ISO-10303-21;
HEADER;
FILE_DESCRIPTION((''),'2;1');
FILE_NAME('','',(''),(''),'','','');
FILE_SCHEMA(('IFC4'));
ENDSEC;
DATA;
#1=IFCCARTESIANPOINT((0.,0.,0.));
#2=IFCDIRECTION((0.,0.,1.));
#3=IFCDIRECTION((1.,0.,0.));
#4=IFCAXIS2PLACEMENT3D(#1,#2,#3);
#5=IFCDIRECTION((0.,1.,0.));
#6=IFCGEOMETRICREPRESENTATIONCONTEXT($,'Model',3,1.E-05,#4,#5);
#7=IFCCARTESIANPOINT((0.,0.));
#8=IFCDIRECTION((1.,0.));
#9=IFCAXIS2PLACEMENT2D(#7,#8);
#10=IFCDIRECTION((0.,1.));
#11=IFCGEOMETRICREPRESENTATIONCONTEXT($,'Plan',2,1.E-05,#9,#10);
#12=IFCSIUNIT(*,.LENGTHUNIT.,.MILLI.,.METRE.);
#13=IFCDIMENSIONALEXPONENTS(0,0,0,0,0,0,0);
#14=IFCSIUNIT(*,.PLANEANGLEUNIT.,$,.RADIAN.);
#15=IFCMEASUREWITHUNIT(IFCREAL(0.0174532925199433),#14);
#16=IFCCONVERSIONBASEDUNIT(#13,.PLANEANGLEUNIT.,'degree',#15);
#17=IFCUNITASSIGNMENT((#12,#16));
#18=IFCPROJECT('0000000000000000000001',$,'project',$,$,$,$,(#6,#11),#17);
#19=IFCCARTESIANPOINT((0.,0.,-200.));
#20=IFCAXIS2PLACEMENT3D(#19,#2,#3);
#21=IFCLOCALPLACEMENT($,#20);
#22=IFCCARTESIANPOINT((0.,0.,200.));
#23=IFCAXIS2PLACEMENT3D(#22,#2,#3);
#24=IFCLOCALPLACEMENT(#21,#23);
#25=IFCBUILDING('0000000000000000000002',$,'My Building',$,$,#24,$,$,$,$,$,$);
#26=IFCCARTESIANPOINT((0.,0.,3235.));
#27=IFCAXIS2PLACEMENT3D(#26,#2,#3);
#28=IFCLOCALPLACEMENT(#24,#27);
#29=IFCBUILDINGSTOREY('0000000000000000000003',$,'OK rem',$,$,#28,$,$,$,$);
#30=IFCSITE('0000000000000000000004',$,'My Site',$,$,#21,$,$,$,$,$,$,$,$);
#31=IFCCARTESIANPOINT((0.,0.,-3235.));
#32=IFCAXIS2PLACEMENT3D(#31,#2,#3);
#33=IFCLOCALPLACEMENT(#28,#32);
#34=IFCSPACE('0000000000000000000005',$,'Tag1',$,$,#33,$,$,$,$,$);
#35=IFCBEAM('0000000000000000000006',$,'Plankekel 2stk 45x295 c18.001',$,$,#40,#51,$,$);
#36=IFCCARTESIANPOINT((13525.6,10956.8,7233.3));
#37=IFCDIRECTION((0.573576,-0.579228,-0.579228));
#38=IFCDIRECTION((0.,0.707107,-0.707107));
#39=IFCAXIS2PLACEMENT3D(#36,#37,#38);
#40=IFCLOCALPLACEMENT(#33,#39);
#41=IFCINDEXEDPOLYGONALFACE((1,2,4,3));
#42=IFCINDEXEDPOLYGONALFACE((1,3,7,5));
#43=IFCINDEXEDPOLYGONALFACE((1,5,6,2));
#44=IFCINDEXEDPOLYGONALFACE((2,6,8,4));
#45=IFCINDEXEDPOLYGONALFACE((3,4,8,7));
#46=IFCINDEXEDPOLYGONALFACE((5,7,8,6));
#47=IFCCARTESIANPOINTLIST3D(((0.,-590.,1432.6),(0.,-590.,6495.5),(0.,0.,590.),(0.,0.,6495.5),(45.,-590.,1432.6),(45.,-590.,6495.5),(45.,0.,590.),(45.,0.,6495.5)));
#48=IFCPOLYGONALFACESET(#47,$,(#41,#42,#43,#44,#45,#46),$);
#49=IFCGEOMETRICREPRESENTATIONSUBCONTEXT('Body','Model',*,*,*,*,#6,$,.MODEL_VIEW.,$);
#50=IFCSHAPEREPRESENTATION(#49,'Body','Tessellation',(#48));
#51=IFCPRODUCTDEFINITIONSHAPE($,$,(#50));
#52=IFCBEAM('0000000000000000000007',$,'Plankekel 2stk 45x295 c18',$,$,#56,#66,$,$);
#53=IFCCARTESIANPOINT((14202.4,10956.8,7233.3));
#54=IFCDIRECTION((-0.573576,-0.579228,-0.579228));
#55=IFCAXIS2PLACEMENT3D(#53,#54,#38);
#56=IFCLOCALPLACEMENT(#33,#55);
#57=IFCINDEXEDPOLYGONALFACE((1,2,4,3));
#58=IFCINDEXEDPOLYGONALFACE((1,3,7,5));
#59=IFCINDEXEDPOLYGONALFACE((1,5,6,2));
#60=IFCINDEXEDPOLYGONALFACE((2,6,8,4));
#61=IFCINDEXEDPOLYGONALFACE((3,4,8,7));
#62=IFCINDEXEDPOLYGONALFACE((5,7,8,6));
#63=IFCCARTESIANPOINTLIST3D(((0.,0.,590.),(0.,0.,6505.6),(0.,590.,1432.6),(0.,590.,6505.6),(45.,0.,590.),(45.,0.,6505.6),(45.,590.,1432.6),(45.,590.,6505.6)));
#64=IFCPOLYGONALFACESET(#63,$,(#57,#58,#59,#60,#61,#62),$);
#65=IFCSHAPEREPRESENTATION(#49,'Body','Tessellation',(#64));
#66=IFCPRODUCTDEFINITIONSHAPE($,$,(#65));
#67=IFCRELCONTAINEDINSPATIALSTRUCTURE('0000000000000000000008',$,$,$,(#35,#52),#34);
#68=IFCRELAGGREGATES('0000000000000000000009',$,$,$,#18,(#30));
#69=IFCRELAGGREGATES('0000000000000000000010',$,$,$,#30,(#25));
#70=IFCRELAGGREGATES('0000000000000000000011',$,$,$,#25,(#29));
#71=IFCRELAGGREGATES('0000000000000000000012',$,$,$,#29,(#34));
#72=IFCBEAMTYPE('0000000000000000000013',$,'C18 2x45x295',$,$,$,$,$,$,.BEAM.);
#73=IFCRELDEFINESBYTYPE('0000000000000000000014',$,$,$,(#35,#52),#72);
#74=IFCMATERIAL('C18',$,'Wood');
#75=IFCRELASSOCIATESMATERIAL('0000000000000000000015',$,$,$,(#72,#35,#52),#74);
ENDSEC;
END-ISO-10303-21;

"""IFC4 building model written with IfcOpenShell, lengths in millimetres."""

from ifc_helpers import new_model, entity, si_unit, converted_unit, direction, frame, origin_with_axes, origin_2d_with_axis, place, context, subcontext, project, spatial, rectangle, extrude, clip, halfspace, material, material_profile, profile_set, profile_usage, type_object, element, save


model = new_model("IFC4")

# Units and contexts
model_context = context("Model", 3, precision=1e-05, world=origin_with_axes(), true_north=direction((0.0, 1.0, 0.0)))
plan_context = context("Plan", 2, precision=1e-05, world=origin_2d_with_axis(), true_north=direction((0.0, 1.0)))
body_context = subcontext(model_context, "Body", "Model", "MODEL_VIEW")
ifc_project = project(units=[si_unit("LENGTHUNIT", "METRE", prefix="MILLI"), converted_unit("PLANEANGLEUNIT", "degree", entity("IfcReal", 0.0174532925199433), si_unit("PLANEANGLEUNIT", "RADIAN"), dimensions=[0, 0, 0, 0, 0, 0, 0])], contexts=[model_context, plan_context])

# Site, building, storey
site_placement = place(None, frame((0.0, 0.0, -200.0), z_axis=(0.0, 0.0, 1.0), x_axis=(1.0, 0.0, 0.0)))
site = spatial("IfcSite", under=ifc_project, at=site_placement, Name="My Site")
building_placement = place(site_placement, frame((0.0, 0.0, 200.0), z_axis=(0.0, 0.0, 1.0), x_axis=(1.0, 0.0, 0.0)))
building = spatial("IfcBuilding", under=site, at=building_placement, Name="My Building")
storey_placement = place(building_placement, frame((0.0, 0.0, 3235.0), z_axis=(0.0, 0.0, 1.0), x_axis=(1.0, 0.0, 0.0)))
storey = spatial("IfcBuildingStorey", under=building, at=storey_placement, Name="OK rem")

# Shared definitions
ifc_material = material(Name="C18", Category="Wood")

# Shared definitions
space_placement = place(storey_placement, frame((0.0, 0.0, -3235.0), z_axis=(0.0, 0.0, 1.0), x_axis=(1.0, 0.0, 0.0)))
space = spatial("IfcSpace", under=storey, at=space_placement, Name="Tag1")

# Beams
ifc_material_profile_1 = material_profile(ifc_material, rectangle(XDim=45.0, YDim=590.0))
ifc_profile_set_1 = profile_set([ifc_material_profile_1])
ifc_profile_usage_1 = profile_usage(ifc_profile_set_1, cardinal=9)
beam_type_1 = type_object("IfcBeamType", Name="C18 2x45x295", PredefinedType="BEAM", material=ifc_profile_set_1)
beam_1_placement = place(space_placement, frame((13525.6, 10956.8, 7233.3), z_axis=(0.573576, -0.579228, -0.579228), x_axis=(0.0, 0.707107, -0.707107)))
element("IfcBeam", 1, at=beam_1_placement, inside=space, type_object=beam_type_1, material=ifc_profile_usage_1, Name="Plankekel 2stk 45x295 c18.001", context=body_context, shape_type="Clipping", body=[
    clip(extrude(rectangle(XDim=45.0, YDim=590.0), frame((22.5, -295.0, 0.0), z_axis=(0.0, 0.0, 1.0), x_axis=(1.0, 0.0, 0.0)), (0.0, 0.0, 1.0), 6495.5), halfspace(frame((-2632.9, 0.0, 590.0), z_axis=(0.0, -0.819153, -0.573576), x_axis=(-1.0, 0.0, 0.0)), False)),
])
ifc_profile_usage_2 = profile_usage(ifc_profile_set_1, cardinal=3)
beam_2_placement = place(space_placement, frame((14202.4, 10956.8, 7233.3), z_axis=(-0.573576, -0.579228, -0.579228), x_axis=(0.0, 0.707107, -0.707107)))
element("IfcBeam", 2, at=beam_2_placement, inside=space, type_object=beam_type_1, material=ifc_profile_usage_2, Name="Plankekel 2stk 45x295 c18", context=body_context, shape_type="Clipping", body=[
    clip(extrude(rectangle(XDim=45.0, YDim=590.0), frame((22.5, 295.0, 0.0), z_axis=(0.0, 0.0, 1.0), x_axis=(1.0, 0.0, 0.0)), (0.0, 0.0, 1.0), 6505.6), halfspace(frame((-2632.9, 0.0, 590.0), z_axis=(0.0, 0.819153, -0.573575), x_axis=(1.0, 0.0, 0.0)), False)),
])

save(model, "model.ifc")
